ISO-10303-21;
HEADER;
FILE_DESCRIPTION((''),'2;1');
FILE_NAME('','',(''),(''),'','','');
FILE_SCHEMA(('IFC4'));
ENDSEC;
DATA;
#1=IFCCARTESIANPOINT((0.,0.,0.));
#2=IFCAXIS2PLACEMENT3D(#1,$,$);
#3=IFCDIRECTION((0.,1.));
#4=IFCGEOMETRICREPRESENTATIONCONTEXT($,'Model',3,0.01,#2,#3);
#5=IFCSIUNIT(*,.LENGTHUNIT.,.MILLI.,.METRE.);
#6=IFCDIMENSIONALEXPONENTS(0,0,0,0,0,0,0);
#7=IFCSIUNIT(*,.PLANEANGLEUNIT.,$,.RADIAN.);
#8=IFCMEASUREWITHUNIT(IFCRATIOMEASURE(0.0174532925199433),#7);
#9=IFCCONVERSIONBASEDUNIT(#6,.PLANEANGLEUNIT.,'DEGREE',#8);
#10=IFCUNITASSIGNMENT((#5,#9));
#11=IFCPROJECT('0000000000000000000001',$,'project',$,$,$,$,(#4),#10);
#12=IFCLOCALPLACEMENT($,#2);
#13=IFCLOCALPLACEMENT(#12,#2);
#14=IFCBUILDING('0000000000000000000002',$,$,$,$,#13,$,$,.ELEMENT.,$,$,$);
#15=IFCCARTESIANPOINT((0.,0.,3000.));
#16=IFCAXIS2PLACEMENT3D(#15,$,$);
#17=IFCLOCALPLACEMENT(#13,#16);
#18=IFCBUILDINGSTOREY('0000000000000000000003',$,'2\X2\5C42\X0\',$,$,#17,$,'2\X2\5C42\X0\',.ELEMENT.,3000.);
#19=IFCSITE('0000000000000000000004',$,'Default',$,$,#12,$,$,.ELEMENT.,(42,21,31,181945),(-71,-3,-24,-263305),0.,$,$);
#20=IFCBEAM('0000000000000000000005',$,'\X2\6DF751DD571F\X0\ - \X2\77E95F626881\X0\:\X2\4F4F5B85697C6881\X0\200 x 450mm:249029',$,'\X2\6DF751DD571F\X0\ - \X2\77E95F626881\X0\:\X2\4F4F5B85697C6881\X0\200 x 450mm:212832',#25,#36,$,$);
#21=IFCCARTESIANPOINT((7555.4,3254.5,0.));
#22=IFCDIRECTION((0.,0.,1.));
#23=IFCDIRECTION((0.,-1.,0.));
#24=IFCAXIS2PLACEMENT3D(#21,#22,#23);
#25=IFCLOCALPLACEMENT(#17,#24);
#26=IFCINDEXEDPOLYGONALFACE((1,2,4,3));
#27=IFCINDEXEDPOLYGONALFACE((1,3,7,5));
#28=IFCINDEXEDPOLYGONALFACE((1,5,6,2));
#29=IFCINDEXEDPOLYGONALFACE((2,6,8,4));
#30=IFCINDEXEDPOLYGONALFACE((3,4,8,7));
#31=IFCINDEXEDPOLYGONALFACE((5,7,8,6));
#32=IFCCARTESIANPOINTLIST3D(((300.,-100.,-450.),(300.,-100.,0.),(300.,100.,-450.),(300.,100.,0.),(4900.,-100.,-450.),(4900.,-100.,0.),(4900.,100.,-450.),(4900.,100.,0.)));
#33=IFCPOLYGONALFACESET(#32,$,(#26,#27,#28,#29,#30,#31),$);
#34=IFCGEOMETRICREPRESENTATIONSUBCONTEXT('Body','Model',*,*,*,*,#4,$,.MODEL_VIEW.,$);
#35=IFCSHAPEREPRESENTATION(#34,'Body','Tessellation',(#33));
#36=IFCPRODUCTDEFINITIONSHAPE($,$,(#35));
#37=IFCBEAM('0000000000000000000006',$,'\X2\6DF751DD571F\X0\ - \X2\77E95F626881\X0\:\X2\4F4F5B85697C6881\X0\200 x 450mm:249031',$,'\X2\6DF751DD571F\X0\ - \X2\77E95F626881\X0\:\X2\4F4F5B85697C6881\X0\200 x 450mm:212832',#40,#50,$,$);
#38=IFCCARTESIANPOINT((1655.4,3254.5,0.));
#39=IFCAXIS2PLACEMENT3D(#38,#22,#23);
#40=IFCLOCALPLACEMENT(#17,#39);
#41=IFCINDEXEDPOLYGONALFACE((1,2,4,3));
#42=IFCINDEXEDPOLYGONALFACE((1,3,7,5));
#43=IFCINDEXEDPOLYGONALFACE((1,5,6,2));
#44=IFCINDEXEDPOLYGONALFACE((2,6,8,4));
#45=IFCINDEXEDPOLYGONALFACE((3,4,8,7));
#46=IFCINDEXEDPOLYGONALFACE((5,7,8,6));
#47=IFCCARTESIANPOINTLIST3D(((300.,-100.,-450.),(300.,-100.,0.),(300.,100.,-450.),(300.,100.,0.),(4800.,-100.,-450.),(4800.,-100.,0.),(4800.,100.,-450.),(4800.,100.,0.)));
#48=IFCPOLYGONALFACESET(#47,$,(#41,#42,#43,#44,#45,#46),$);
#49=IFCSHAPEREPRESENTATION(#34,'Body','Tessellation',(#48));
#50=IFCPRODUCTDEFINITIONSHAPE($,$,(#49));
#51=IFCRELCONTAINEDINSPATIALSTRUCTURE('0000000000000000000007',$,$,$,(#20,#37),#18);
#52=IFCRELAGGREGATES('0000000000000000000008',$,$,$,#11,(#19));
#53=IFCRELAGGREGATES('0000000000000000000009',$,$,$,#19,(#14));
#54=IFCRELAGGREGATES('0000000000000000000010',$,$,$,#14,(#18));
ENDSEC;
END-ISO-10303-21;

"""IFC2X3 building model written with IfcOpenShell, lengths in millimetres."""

from ifc_helpers import new_model, entity, si_unit, converted_unit, direction, frame, frame_2d, origin, place, context, subcontext, project, spatial, rectangle, extrude, element, save


model = new_model("IFC2X3")

# Units and contexts
model_context = context("Model", 3, precision=0.01, world=origin(), true_north=direction((0.0, 1.0)))
body_context = subcontext(model_context, "Body", "Model", "MODEL_VIEW")
ifc_project = project(units=[si_unit("LENGTHUNIT", "METRE", prefix="MILLI"), converted_unit("PLANEANGLEUNIT", "DEGREE", entity("IfcRatioMeasure", 0.0174532925199433), si_unit("PLANEANGLEUNIT", "RADIAN"), dimensions=[0, 0, 0, 0, 0, 0, 0])], contexts=[model_context])

# Site, building, storey
site_placement = place(None, origin())
site = spatial("IfcSite", under=ifc_project, at=site_placement, Name="Default", CompositionType="ELEMENT", RefLatitude=(42, 21, 31, 181945), RefLongitude=(-71, -3, -24, -263305), RefElevation=0.0)
building_placement = place(site_placement, origin())
building = spatial("IfcBuilding", under=site, at=building_placement, CompositionType="ELEMENT")
storey_placement = place(building_placement, frame((0.0, 0.0, 3000.0)))
storey = spatial("IfcBuildingStorey", under=building, at=storey_placement, Name="2层", LongName="2层", CompositionType="ELEMENT", Elevation=3000.0)

# Beams
beam_1_placement = place(storey_placement, frame((7555.4, 3254.5, 0.0), z_axis=(0.0, 0.0, 1.0), x_axis=(0.0, -1.0, 0.0)))
element("IfcBeam", 1, at=beam_1_placement, inside=storey, Name="混凝土 - 矩形梁:住宅楼梁200 x 450mm:249029", ObjectType="混凝土 - 矩形梁:住宅楼梁200 x 450mm:212832", context=body_context, shape_type="SweptSolid", body=[
    extrude(rectangle(XDim=450.0, YDim=200.0, at=frame_2d((0.0, 0.0), x_axis=(1.0, 0.0))), frame((300.0, 0.0, -225.0), z_axis=(1.0, 0.0, 0.0), x_axis=(0.0, 0.0, -1.0)), (0.0, 0.0, 1.0), 4600.0),
])
beam_2_placement = place(storey_placement, frame((1655.4, 3254.5, 0.0), z_axis=(0.0, 0.0, 1.0), x_axis=(0.0, -1.0, 0.0)))
element("IfcBeam", 2, at=beam_2_placement, inside=storey, Name="混凝土 - 矩形梁:住宅楼梁200 x 450mm:249031", ObjectType="混凝土 - 矩形梁:住宅楼梁200 x 450mm:212832", context=body_context, shape_type="SweptSolid", body=[
    extrude(rectangle(XDim=450.0, YDim=200.0, at=frame_2d((0.0, 0.0), x_axis=(1.0, 0.0))), frame((300.0, 0.0, -225.0), z_axis=(1.0, 0.0, 0.0), x_axis=(0.0, 0.0, -1.0)), (0.0, 0.0, 1.0), 4500.0),
])

save(model, "model.ifc")
